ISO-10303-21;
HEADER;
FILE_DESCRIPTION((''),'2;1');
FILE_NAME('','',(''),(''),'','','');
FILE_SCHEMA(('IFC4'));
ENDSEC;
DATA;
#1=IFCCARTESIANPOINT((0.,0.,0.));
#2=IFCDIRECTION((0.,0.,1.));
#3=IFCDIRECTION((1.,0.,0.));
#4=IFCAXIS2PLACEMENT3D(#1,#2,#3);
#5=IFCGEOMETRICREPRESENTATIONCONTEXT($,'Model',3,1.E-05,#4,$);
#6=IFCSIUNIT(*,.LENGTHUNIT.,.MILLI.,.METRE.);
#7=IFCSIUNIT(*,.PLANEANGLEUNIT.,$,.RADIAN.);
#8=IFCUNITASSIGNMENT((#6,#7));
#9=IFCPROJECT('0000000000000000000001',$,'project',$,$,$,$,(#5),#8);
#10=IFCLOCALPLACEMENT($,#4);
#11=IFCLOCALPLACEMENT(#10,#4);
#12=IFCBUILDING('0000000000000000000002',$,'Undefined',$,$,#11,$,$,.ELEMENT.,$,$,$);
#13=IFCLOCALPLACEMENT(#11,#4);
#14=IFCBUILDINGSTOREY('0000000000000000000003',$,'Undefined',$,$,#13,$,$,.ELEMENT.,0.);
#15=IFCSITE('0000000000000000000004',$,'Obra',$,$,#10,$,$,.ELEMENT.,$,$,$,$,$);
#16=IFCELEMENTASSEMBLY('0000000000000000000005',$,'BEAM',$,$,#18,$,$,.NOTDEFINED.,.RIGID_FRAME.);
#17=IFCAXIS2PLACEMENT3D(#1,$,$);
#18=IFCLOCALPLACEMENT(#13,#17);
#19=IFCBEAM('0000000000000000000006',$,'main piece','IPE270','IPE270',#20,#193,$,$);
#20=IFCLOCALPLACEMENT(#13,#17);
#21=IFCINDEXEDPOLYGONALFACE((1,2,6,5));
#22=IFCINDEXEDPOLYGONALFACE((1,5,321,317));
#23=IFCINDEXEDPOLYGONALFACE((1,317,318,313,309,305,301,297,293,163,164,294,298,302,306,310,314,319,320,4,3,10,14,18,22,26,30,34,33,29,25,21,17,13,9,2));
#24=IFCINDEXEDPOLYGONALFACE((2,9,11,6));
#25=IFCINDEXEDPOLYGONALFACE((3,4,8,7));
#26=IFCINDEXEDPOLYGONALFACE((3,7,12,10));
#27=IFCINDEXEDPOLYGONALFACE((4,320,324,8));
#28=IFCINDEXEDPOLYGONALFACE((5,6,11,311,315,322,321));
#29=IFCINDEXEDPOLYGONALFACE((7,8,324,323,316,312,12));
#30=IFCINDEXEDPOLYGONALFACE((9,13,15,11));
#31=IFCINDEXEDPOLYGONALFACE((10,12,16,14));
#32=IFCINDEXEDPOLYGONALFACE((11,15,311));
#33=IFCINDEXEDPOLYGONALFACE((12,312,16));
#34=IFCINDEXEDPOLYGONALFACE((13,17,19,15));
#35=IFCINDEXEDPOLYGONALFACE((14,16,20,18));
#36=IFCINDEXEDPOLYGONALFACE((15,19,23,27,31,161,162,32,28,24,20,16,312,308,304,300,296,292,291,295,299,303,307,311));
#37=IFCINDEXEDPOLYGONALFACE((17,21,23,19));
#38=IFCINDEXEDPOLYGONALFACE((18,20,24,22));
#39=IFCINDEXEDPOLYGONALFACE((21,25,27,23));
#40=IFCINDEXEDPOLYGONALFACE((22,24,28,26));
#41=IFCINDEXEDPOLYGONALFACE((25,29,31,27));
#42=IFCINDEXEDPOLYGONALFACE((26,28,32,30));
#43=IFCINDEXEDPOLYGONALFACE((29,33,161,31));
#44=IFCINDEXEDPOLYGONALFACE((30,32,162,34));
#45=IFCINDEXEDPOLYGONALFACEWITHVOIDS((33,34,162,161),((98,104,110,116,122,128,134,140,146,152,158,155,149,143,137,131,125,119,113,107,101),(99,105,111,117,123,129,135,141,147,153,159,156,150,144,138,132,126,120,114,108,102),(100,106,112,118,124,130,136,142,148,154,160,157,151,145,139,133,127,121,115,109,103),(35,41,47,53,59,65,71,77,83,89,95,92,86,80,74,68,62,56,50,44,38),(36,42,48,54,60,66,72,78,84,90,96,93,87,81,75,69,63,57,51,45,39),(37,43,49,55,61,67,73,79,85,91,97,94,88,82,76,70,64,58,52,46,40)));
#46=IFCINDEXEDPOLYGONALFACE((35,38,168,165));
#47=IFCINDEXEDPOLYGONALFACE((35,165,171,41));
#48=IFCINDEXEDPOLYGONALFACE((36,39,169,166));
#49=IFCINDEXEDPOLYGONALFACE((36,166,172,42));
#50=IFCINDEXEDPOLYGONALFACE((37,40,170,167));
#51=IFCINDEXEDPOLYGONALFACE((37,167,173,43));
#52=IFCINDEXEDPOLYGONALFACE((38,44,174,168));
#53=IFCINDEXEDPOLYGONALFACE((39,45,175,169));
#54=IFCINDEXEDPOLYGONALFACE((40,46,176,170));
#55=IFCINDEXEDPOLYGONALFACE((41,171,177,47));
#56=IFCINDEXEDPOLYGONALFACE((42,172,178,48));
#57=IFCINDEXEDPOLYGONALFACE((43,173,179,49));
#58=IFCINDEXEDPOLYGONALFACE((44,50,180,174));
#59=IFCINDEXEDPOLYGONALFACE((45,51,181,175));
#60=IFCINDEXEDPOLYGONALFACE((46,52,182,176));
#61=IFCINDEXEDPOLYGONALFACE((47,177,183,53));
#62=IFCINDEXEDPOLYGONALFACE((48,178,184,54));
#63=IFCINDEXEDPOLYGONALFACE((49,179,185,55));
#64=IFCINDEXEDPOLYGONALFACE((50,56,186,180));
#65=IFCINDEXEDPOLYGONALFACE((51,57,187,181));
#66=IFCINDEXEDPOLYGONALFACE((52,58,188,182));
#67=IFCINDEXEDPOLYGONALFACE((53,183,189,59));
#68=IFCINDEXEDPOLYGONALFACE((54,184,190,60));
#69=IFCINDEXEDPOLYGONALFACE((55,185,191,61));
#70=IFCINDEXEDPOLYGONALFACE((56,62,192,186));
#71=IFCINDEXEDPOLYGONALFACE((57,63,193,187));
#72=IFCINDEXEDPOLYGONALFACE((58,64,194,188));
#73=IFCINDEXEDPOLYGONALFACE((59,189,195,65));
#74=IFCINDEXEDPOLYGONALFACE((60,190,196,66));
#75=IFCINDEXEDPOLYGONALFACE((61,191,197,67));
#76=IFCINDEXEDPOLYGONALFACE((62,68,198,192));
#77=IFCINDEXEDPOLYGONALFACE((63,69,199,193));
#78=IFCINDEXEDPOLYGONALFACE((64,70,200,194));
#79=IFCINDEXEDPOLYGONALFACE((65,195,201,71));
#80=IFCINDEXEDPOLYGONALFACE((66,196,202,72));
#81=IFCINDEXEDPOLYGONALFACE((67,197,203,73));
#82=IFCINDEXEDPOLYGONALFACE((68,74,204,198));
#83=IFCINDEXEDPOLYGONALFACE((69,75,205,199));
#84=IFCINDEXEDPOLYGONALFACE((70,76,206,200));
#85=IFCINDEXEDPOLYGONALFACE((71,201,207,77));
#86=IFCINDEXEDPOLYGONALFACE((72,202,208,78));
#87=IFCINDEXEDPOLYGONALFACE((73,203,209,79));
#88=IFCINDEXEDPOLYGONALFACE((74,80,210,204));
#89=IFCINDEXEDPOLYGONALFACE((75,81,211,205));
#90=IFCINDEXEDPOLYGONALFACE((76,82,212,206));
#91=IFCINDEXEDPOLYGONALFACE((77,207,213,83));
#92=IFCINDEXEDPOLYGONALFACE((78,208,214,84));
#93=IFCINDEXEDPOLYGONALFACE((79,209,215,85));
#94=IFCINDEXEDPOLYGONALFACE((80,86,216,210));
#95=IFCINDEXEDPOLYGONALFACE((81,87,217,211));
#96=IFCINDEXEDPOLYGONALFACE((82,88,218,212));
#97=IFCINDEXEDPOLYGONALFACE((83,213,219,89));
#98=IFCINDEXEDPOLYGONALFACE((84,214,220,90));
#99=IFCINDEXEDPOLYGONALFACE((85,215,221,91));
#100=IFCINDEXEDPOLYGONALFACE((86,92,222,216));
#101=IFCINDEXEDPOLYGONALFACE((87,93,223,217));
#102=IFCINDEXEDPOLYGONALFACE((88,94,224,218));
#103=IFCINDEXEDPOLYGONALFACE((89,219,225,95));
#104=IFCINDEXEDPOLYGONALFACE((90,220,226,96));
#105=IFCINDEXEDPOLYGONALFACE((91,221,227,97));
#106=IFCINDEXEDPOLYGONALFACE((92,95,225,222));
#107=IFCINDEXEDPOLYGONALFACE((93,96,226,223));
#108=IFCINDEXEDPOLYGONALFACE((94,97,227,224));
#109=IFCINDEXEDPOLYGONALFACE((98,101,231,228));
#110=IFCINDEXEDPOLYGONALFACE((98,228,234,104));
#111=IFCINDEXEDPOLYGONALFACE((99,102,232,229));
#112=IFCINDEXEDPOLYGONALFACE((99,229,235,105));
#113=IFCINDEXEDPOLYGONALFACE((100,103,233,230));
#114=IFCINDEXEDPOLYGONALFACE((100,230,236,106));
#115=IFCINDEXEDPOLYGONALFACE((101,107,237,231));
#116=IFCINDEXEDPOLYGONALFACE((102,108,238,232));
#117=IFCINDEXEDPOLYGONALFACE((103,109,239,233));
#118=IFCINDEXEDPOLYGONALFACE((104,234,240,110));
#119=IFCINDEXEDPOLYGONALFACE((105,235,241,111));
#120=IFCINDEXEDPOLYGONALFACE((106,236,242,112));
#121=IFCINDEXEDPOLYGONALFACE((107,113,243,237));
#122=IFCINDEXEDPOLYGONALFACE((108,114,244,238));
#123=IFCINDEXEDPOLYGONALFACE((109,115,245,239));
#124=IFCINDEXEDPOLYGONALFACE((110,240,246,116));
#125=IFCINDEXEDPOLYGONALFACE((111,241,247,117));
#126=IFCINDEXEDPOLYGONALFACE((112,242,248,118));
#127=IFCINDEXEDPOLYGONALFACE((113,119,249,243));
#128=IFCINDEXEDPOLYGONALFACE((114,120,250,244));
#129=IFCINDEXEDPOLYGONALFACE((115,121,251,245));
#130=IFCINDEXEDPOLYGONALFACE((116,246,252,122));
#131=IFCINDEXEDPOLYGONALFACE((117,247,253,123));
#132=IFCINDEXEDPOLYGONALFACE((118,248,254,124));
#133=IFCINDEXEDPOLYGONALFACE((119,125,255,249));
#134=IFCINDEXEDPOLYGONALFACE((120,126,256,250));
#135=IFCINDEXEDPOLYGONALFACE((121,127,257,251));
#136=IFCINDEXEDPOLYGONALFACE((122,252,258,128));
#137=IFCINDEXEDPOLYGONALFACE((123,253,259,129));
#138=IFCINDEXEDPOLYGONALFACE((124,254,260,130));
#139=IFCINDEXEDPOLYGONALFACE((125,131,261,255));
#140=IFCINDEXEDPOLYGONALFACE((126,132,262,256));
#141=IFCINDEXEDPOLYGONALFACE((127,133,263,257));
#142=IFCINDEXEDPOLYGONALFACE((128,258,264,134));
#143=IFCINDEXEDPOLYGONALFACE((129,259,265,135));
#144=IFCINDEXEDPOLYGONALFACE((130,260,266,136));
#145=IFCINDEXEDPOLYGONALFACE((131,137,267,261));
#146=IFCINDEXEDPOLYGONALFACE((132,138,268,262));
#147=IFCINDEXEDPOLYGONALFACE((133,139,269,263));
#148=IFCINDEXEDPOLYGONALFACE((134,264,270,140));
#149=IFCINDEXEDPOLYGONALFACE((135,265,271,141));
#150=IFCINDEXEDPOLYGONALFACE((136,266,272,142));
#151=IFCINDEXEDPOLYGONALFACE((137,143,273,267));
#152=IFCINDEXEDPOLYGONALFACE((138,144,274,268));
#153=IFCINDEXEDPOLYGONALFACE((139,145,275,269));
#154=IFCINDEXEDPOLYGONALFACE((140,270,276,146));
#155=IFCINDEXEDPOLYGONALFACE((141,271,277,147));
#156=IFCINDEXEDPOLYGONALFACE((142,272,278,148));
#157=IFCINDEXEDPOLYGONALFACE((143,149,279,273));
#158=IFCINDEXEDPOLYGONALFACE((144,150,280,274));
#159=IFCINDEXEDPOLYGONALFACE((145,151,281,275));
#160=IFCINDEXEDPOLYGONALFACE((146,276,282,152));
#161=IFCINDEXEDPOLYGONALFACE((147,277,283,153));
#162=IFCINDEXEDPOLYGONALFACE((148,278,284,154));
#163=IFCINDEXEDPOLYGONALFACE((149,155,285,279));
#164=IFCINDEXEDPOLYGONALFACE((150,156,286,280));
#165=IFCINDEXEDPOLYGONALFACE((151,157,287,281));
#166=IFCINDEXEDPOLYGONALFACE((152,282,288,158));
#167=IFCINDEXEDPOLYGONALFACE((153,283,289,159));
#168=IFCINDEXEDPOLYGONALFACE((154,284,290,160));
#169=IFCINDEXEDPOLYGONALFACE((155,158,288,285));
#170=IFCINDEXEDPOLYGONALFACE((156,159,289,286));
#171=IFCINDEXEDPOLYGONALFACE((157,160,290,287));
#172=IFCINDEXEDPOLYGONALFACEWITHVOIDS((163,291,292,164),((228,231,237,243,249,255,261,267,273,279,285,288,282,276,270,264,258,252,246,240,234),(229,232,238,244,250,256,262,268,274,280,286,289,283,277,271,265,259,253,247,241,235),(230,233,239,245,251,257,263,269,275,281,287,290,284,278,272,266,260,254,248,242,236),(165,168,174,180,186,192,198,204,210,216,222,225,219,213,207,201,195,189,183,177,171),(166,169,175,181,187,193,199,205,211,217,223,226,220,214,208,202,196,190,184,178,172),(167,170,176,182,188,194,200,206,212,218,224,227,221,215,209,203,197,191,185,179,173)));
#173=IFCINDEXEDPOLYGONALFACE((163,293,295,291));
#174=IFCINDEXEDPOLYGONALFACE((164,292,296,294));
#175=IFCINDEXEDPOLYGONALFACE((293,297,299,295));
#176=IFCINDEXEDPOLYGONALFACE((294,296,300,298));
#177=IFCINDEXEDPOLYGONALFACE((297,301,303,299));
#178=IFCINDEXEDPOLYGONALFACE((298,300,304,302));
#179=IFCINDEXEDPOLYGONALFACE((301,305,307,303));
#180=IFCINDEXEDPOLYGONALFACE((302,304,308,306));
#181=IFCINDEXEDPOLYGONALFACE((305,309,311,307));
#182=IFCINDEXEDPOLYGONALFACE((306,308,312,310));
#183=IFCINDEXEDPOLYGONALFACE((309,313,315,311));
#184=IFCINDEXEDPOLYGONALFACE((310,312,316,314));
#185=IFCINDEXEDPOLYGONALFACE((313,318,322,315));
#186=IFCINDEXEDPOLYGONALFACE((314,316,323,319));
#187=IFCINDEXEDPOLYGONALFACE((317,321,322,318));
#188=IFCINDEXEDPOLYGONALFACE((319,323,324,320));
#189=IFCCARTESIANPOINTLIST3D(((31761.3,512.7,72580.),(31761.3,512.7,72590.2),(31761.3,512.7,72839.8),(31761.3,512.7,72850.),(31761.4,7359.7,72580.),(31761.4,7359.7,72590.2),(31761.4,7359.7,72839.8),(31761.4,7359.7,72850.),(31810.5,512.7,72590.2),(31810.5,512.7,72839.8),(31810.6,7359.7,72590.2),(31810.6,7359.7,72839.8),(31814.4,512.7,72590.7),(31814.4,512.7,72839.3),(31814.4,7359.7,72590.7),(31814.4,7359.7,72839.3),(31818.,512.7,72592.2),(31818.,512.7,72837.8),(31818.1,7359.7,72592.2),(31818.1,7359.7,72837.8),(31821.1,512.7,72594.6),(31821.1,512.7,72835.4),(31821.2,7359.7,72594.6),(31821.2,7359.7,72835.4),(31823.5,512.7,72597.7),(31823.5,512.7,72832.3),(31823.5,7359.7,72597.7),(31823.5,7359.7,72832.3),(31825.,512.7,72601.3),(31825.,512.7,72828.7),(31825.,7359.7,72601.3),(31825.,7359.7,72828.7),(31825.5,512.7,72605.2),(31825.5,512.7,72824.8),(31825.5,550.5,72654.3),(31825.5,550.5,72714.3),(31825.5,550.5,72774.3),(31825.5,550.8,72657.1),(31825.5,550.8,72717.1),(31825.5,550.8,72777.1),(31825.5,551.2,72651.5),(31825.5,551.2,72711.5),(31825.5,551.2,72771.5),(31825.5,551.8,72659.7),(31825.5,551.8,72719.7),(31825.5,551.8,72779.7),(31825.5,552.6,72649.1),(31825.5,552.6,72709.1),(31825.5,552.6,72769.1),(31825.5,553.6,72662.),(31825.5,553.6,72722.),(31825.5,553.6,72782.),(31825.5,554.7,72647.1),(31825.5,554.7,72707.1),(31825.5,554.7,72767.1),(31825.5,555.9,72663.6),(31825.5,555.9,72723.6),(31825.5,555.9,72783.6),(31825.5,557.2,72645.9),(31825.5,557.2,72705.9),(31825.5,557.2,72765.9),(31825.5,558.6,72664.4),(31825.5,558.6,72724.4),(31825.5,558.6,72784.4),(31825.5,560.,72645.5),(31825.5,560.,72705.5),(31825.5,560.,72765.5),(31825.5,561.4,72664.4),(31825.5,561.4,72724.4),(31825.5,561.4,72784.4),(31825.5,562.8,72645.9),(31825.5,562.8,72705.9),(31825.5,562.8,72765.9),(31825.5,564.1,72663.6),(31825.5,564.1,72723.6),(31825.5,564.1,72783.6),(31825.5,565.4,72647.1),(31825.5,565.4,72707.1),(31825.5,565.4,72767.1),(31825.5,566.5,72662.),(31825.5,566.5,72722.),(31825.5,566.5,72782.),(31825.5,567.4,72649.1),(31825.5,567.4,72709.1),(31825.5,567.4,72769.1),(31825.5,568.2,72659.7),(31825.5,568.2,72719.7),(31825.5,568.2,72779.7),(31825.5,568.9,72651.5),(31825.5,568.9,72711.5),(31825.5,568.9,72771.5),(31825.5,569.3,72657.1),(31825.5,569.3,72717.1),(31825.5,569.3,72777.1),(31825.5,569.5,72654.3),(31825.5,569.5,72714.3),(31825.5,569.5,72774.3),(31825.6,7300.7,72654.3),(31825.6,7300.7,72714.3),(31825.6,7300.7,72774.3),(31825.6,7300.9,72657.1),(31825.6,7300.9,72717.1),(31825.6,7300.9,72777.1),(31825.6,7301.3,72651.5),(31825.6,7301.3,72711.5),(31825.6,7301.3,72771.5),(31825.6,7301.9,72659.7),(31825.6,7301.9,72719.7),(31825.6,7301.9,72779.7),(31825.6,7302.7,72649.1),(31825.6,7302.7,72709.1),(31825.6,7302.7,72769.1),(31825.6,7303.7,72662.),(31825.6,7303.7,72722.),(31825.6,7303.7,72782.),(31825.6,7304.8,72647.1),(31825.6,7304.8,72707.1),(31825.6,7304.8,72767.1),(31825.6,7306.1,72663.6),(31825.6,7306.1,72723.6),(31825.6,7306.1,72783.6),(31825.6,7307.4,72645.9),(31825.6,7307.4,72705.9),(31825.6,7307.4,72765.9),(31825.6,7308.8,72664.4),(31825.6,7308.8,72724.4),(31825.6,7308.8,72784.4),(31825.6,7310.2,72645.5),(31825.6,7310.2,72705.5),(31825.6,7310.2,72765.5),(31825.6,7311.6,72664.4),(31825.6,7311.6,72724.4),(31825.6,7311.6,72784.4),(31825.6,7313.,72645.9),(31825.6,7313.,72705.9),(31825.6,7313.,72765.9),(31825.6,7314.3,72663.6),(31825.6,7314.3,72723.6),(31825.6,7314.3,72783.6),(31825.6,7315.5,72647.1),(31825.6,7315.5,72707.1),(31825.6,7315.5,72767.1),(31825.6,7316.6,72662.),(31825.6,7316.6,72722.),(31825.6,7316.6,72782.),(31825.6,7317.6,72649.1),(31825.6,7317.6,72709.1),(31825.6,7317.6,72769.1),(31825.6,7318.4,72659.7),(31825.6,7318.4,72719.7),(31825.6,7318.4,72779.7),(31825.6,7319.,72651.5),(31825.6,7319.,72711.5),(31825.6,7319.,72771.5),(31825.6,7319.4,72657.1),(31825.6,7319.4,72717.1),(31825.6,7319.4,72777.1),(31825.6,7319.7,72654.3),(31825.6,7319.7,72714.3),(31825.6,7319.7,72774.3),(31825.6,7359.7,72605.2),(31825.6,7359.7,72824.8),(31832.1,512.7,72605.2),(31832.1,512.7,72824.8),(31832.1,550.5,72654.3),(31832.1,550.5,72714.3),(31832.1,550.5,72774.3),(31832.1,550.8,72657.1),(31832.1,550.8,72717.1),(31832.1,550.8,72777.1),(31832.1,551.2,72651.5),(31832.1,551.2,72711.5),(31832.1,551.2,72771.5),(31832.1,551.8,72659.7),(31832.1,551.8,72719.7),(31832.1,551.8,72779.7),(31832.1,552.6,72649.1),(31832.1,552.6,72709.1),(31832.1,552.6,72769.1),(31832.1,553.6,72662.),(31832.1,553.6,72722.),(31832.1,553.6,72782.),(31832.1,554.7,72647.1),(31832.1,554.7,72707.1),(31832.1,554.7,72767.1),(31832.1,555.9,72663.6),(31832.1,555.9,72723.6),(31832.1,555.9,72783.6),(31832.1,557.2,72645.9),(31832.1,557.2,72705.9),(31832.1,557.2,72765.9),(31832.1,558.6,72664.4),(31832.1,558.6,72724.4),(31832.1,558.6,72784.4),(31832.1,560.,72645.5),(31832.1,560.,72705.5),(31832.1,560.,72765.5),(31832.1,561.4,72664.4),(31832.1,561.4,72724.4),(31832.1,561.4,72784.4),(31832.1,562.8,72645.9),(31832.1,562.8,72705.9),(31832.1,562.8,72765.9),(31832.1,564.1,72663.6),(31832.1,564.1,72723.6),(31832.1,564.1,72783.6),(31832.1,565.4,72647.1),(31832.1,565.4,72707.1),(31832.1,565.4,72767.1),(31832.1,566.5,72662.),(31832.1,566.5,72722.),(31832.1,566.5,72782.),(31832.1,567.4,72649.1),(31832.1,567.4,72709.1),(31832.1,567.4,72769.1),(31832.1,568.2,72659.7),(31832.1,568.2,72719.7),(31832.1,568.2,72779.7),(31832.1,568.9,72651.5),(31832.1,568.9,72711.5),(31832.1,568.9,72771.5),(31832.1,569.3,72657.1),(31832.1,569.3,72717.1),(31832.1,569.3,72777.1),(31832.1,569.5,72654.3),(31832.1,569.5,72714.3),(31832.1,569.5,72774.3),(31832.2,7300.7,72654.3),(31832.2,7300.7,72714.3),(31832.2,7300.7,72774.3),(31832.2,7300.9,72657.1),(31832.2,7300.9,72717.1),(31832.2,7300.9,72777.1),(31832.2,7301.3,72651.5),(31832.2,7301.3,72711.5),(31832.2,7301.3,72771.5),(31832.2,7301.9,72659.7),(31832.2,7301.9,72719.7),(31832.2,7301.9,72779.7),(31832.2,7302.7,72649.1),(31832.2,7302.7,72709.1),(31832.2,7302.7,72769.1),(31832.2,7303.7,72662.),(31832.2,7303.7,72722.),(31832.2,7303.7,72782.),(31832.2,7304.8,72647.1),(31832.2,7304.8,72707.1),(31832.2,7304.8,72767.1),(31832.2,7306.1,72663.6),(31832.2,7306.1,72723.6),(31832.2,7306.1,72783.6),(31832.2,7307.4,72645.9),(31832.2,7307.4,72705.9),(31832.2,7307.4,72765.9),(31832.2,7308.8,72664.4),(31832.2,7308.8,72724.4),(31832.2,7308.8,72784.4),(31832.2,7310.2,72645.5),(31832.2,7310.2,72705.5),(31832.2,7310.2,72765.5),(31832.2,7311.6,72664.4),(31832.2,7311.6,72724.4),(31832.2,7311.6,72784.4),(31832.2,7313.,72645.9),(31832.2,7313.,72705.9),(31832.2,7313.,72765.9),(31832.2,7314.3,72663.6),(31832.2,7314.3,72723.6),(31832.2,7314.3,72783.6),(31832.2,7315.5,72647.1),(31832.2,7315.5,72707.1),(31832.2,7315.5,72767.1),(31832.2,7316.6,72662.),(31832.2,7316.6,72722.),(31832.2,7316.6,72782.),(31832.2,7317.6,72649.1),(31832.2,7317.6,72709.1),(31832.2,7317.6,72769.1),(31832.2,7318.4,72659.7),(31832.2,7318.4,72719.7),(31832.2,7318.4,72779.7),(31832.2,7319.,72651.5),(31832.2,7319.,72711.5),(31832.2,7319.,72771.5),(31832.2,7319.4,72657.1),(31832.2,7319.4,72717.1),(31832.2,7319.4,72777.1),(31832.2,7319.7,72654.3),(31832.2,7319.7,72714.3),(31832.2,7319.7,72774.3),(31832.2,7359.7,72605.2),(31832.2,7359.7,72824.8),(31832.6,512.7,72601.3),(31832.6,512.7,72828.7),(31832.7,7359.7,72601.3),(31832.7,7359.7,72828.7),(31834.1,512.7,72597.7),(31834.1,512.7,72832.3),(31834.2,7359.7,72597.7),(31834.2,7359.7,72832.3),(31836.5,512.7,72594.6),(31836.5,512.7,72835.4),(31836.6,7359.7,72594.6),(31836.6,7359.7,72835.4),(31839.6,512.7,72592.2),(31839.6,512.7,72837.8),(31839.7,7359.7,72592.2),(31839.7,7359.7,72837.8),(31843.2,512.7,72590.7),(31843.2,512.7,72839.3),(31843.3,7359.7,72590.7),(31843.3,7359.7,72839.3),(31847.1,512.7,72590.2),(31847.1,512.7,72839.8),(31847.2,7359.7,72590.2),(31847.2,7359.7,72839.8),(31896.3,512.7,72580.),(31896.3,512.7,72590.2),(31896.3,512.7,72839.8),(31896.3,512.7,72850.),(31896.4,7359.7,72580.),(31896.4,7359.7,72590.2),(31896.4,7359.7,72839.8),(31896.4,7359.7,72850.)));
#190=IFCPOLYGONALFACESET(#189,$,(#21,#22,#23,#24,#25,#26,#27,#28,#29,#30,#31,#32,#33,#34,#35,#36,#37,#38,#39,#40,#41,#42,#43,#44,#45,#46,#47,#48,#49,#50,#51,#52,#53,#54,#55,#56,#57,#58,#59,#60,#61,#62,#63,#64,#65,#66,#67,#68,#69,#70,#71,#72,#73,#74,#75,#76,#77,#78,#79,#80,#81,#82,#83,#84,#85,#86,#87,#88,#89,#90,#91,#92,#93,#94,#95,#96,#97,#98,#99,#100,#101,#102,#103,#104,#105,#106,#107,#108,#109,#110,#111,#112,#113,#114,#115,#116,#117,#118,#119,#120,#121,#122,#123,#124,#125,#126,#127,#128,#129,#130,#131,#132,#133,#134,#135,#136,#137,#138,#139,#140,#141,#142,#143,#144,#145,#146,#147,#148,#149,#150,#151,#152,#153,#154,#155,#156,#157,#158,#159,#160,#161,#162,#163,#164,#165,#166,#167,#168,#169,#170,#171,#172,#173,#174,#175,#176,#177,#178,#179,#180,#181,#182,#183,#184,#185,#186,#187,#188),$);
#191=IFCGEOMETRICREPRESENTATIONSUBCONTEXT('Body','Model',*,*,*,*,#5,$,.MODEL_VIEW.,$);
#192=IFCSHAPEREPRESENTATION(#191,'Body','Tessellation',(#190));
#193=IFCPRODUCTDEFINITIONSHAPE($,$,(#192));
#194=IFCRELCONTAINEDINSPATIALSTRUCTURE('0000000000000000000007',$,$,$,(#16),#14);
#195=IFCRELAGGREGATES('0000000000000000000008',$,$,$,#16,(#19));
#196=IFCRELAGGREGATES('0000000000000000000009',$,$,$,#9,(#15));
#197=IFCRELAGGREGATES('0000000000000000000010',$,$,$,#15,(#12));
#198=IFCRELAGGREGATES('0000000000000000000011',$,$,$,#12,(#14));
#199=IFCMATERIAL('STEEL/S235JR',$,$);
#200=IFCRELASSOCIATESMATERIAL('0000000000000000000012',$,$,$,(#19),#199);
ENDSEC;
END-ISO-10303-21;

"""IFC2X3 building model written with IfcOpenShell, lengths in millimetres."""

from ifc_helpers import new_model, si_unit, frame, origin_with_axes, origin_2d_with_axis, place, context, subcontext, project, spatial, circle, i_section, extrude, clip, halfspace, source, transform, mapped, material, element, aggregate, save


model = new_model("IFC2X3")

# Units and contexts
model_context = context("Model", 3, precision=1e-05, world=origin_with_axes())
body_context = subcontext(model_context, "Body", "Model", "MODEL_VIEW")
ifc_project = project(units=[si_unit("LENGTHUNIT", "METRE", prefix="MILLI"), si_unit("PLANEANGLEUNIT", "RADIAN")], contexts=[model_context])

# Site, building, storey
site_placement = place(None, origin_with_axes())
site = spatial("IfcSite", under=ifc_project, at=site_placement, Name="Obra", CompositionType="ELEMENT")
building_placement = place(site_placement, origin_with_axes())
building = spatial("IfcBuilding", under=site, at=building_placement, Name="Undefined", CompositionType="ELEMENT")
storey_placement = place(building_placement, origin_with_axes())
storey = spatial("IfcBuildingStorey", under=building, at=storey_placement, Name="Undefined", CompositionType="ELEMENT", Elevation=0.0)

# Shared definitions
ifc_material_1 = material(Name="STEEL/S235JR")

# Element assembly, beam, openings
assembly_1_placement = place(storey_placement, origin_with_axes())
assembly_1 = element("IfcElementAssembly", 1, at=assembly_1_placement, inside=storey, Name="BEAM", AssemblyPlace="NOTDEFINED", PredefinedType="RIGID_FRAME")
beam_1_placement = place(assembly_1_placement, frame((31828.8, 512.7, 72715.0), z_axis=(0.0, 0.0, 1.0), x_axis=(0.000013, 1.0, 0.0)))
beam_1 = element("IfcBeam", 2, at=beam_1_placement, material=ifc_material_1, Name="main piece", Description="IPE270", ObjectType="IPE270", context=body_context, shape_type="Clipping", body=[
    clip(clip(extrude(i_section(OverallWidth=135.0, OverallDepth=270.0, WebThickness=6.6, FlangeThickness=10.2, FilletRadius=15.0, at=origin_2d_with_axis()), frame((6857.4, 0.0, 0.0), z_axis=(-1.0, 0.0, 0.0), x_axis=(0.0, -1.0, 0.0)), (0.0, 0.0, 1.0), 6857.4), halfspace(frame((6847.0, -60.0, -120.0), z_axis=(1.0, 0.000037, 0.0), x_axis=(0.0, 0.0, 1.0)), False)), halfspace(frame((-2.2, 60.0, -120.0), z_axis=(-1.0, -0.000034, 0.0), x_axis=(0.0, 0.0, 1.0)), False)),
])
shared_shape_1 = source(origin_with_axes(), body_context, "Body", "SweptSolid", [
    extrude(circle(Radius=9.5, at=origin_2d_with_axis()), frame((0.0, -3.4, 0.0), z_axis=(0.0, 1.0, 0.0), x_axis=(1.0, 0.0, 0.0)), (0.0, 0.0, 1.0), 6.8),
])
opening_1_placement = place(assembly_1_placement, frame((31828.9, 7360.2, 72835.0), z_axis=(0.000005, -1.0, 0.0), x_axis=(0.0, 0.0, -1.0)))
element("IfcOpeningElement", 3, at=opening_1_placement, cuts=beam_1, ObjectType="Opening", context=body_context, shape_type="MappedRepresentation", body=[
    mapped(shared_shape_1, transform((60.0, 0.0, 50.0))),
    mapped(shared_shape_1, transform((120.0, 0.0, 50.0))),
    mapped(shared_shape_1, transform((180.0, 0.0, 50.0))),
])
shared_shape_2 = source(origin_with_axes(), body_context, "Body", "SweptSolid", [
    extrude(circle(Radius=9.5, at=origin_2d_with_axis()), frame((0.0, -3.4, 0.0), z_axis=(0.0, 1.0, 0.0), x_axis=(1.0, 0.0, 0.0)), (0.0, 0.0, 1.0), 6.8),
])
opening_2_placement = place(assembly_1_placement, frame((31828.8, 510.0, 72835.0), z_axis=(-0.000002, 1.0, 0.0), x_axis=(0.0, 0.0, -1.0)))
element("IfcOpeningElement", 4, at=opening_2_placement, cuts=beam_1, ObjectType="Opening", context=body_context, shape_type="MappedRepresentation", body=[
    mapped(shared_shape_2, transform((60.0, 0.0, 50.0))),
    mapped(shared_shape_2, transform((120.0, 0.0, 50.0))),
    mapped(shared_shape_2, transform((180.0, 0.0, 50.0))),
])
aggregate(assembly_1, [beam_1])

save(model, "model.ifc")
